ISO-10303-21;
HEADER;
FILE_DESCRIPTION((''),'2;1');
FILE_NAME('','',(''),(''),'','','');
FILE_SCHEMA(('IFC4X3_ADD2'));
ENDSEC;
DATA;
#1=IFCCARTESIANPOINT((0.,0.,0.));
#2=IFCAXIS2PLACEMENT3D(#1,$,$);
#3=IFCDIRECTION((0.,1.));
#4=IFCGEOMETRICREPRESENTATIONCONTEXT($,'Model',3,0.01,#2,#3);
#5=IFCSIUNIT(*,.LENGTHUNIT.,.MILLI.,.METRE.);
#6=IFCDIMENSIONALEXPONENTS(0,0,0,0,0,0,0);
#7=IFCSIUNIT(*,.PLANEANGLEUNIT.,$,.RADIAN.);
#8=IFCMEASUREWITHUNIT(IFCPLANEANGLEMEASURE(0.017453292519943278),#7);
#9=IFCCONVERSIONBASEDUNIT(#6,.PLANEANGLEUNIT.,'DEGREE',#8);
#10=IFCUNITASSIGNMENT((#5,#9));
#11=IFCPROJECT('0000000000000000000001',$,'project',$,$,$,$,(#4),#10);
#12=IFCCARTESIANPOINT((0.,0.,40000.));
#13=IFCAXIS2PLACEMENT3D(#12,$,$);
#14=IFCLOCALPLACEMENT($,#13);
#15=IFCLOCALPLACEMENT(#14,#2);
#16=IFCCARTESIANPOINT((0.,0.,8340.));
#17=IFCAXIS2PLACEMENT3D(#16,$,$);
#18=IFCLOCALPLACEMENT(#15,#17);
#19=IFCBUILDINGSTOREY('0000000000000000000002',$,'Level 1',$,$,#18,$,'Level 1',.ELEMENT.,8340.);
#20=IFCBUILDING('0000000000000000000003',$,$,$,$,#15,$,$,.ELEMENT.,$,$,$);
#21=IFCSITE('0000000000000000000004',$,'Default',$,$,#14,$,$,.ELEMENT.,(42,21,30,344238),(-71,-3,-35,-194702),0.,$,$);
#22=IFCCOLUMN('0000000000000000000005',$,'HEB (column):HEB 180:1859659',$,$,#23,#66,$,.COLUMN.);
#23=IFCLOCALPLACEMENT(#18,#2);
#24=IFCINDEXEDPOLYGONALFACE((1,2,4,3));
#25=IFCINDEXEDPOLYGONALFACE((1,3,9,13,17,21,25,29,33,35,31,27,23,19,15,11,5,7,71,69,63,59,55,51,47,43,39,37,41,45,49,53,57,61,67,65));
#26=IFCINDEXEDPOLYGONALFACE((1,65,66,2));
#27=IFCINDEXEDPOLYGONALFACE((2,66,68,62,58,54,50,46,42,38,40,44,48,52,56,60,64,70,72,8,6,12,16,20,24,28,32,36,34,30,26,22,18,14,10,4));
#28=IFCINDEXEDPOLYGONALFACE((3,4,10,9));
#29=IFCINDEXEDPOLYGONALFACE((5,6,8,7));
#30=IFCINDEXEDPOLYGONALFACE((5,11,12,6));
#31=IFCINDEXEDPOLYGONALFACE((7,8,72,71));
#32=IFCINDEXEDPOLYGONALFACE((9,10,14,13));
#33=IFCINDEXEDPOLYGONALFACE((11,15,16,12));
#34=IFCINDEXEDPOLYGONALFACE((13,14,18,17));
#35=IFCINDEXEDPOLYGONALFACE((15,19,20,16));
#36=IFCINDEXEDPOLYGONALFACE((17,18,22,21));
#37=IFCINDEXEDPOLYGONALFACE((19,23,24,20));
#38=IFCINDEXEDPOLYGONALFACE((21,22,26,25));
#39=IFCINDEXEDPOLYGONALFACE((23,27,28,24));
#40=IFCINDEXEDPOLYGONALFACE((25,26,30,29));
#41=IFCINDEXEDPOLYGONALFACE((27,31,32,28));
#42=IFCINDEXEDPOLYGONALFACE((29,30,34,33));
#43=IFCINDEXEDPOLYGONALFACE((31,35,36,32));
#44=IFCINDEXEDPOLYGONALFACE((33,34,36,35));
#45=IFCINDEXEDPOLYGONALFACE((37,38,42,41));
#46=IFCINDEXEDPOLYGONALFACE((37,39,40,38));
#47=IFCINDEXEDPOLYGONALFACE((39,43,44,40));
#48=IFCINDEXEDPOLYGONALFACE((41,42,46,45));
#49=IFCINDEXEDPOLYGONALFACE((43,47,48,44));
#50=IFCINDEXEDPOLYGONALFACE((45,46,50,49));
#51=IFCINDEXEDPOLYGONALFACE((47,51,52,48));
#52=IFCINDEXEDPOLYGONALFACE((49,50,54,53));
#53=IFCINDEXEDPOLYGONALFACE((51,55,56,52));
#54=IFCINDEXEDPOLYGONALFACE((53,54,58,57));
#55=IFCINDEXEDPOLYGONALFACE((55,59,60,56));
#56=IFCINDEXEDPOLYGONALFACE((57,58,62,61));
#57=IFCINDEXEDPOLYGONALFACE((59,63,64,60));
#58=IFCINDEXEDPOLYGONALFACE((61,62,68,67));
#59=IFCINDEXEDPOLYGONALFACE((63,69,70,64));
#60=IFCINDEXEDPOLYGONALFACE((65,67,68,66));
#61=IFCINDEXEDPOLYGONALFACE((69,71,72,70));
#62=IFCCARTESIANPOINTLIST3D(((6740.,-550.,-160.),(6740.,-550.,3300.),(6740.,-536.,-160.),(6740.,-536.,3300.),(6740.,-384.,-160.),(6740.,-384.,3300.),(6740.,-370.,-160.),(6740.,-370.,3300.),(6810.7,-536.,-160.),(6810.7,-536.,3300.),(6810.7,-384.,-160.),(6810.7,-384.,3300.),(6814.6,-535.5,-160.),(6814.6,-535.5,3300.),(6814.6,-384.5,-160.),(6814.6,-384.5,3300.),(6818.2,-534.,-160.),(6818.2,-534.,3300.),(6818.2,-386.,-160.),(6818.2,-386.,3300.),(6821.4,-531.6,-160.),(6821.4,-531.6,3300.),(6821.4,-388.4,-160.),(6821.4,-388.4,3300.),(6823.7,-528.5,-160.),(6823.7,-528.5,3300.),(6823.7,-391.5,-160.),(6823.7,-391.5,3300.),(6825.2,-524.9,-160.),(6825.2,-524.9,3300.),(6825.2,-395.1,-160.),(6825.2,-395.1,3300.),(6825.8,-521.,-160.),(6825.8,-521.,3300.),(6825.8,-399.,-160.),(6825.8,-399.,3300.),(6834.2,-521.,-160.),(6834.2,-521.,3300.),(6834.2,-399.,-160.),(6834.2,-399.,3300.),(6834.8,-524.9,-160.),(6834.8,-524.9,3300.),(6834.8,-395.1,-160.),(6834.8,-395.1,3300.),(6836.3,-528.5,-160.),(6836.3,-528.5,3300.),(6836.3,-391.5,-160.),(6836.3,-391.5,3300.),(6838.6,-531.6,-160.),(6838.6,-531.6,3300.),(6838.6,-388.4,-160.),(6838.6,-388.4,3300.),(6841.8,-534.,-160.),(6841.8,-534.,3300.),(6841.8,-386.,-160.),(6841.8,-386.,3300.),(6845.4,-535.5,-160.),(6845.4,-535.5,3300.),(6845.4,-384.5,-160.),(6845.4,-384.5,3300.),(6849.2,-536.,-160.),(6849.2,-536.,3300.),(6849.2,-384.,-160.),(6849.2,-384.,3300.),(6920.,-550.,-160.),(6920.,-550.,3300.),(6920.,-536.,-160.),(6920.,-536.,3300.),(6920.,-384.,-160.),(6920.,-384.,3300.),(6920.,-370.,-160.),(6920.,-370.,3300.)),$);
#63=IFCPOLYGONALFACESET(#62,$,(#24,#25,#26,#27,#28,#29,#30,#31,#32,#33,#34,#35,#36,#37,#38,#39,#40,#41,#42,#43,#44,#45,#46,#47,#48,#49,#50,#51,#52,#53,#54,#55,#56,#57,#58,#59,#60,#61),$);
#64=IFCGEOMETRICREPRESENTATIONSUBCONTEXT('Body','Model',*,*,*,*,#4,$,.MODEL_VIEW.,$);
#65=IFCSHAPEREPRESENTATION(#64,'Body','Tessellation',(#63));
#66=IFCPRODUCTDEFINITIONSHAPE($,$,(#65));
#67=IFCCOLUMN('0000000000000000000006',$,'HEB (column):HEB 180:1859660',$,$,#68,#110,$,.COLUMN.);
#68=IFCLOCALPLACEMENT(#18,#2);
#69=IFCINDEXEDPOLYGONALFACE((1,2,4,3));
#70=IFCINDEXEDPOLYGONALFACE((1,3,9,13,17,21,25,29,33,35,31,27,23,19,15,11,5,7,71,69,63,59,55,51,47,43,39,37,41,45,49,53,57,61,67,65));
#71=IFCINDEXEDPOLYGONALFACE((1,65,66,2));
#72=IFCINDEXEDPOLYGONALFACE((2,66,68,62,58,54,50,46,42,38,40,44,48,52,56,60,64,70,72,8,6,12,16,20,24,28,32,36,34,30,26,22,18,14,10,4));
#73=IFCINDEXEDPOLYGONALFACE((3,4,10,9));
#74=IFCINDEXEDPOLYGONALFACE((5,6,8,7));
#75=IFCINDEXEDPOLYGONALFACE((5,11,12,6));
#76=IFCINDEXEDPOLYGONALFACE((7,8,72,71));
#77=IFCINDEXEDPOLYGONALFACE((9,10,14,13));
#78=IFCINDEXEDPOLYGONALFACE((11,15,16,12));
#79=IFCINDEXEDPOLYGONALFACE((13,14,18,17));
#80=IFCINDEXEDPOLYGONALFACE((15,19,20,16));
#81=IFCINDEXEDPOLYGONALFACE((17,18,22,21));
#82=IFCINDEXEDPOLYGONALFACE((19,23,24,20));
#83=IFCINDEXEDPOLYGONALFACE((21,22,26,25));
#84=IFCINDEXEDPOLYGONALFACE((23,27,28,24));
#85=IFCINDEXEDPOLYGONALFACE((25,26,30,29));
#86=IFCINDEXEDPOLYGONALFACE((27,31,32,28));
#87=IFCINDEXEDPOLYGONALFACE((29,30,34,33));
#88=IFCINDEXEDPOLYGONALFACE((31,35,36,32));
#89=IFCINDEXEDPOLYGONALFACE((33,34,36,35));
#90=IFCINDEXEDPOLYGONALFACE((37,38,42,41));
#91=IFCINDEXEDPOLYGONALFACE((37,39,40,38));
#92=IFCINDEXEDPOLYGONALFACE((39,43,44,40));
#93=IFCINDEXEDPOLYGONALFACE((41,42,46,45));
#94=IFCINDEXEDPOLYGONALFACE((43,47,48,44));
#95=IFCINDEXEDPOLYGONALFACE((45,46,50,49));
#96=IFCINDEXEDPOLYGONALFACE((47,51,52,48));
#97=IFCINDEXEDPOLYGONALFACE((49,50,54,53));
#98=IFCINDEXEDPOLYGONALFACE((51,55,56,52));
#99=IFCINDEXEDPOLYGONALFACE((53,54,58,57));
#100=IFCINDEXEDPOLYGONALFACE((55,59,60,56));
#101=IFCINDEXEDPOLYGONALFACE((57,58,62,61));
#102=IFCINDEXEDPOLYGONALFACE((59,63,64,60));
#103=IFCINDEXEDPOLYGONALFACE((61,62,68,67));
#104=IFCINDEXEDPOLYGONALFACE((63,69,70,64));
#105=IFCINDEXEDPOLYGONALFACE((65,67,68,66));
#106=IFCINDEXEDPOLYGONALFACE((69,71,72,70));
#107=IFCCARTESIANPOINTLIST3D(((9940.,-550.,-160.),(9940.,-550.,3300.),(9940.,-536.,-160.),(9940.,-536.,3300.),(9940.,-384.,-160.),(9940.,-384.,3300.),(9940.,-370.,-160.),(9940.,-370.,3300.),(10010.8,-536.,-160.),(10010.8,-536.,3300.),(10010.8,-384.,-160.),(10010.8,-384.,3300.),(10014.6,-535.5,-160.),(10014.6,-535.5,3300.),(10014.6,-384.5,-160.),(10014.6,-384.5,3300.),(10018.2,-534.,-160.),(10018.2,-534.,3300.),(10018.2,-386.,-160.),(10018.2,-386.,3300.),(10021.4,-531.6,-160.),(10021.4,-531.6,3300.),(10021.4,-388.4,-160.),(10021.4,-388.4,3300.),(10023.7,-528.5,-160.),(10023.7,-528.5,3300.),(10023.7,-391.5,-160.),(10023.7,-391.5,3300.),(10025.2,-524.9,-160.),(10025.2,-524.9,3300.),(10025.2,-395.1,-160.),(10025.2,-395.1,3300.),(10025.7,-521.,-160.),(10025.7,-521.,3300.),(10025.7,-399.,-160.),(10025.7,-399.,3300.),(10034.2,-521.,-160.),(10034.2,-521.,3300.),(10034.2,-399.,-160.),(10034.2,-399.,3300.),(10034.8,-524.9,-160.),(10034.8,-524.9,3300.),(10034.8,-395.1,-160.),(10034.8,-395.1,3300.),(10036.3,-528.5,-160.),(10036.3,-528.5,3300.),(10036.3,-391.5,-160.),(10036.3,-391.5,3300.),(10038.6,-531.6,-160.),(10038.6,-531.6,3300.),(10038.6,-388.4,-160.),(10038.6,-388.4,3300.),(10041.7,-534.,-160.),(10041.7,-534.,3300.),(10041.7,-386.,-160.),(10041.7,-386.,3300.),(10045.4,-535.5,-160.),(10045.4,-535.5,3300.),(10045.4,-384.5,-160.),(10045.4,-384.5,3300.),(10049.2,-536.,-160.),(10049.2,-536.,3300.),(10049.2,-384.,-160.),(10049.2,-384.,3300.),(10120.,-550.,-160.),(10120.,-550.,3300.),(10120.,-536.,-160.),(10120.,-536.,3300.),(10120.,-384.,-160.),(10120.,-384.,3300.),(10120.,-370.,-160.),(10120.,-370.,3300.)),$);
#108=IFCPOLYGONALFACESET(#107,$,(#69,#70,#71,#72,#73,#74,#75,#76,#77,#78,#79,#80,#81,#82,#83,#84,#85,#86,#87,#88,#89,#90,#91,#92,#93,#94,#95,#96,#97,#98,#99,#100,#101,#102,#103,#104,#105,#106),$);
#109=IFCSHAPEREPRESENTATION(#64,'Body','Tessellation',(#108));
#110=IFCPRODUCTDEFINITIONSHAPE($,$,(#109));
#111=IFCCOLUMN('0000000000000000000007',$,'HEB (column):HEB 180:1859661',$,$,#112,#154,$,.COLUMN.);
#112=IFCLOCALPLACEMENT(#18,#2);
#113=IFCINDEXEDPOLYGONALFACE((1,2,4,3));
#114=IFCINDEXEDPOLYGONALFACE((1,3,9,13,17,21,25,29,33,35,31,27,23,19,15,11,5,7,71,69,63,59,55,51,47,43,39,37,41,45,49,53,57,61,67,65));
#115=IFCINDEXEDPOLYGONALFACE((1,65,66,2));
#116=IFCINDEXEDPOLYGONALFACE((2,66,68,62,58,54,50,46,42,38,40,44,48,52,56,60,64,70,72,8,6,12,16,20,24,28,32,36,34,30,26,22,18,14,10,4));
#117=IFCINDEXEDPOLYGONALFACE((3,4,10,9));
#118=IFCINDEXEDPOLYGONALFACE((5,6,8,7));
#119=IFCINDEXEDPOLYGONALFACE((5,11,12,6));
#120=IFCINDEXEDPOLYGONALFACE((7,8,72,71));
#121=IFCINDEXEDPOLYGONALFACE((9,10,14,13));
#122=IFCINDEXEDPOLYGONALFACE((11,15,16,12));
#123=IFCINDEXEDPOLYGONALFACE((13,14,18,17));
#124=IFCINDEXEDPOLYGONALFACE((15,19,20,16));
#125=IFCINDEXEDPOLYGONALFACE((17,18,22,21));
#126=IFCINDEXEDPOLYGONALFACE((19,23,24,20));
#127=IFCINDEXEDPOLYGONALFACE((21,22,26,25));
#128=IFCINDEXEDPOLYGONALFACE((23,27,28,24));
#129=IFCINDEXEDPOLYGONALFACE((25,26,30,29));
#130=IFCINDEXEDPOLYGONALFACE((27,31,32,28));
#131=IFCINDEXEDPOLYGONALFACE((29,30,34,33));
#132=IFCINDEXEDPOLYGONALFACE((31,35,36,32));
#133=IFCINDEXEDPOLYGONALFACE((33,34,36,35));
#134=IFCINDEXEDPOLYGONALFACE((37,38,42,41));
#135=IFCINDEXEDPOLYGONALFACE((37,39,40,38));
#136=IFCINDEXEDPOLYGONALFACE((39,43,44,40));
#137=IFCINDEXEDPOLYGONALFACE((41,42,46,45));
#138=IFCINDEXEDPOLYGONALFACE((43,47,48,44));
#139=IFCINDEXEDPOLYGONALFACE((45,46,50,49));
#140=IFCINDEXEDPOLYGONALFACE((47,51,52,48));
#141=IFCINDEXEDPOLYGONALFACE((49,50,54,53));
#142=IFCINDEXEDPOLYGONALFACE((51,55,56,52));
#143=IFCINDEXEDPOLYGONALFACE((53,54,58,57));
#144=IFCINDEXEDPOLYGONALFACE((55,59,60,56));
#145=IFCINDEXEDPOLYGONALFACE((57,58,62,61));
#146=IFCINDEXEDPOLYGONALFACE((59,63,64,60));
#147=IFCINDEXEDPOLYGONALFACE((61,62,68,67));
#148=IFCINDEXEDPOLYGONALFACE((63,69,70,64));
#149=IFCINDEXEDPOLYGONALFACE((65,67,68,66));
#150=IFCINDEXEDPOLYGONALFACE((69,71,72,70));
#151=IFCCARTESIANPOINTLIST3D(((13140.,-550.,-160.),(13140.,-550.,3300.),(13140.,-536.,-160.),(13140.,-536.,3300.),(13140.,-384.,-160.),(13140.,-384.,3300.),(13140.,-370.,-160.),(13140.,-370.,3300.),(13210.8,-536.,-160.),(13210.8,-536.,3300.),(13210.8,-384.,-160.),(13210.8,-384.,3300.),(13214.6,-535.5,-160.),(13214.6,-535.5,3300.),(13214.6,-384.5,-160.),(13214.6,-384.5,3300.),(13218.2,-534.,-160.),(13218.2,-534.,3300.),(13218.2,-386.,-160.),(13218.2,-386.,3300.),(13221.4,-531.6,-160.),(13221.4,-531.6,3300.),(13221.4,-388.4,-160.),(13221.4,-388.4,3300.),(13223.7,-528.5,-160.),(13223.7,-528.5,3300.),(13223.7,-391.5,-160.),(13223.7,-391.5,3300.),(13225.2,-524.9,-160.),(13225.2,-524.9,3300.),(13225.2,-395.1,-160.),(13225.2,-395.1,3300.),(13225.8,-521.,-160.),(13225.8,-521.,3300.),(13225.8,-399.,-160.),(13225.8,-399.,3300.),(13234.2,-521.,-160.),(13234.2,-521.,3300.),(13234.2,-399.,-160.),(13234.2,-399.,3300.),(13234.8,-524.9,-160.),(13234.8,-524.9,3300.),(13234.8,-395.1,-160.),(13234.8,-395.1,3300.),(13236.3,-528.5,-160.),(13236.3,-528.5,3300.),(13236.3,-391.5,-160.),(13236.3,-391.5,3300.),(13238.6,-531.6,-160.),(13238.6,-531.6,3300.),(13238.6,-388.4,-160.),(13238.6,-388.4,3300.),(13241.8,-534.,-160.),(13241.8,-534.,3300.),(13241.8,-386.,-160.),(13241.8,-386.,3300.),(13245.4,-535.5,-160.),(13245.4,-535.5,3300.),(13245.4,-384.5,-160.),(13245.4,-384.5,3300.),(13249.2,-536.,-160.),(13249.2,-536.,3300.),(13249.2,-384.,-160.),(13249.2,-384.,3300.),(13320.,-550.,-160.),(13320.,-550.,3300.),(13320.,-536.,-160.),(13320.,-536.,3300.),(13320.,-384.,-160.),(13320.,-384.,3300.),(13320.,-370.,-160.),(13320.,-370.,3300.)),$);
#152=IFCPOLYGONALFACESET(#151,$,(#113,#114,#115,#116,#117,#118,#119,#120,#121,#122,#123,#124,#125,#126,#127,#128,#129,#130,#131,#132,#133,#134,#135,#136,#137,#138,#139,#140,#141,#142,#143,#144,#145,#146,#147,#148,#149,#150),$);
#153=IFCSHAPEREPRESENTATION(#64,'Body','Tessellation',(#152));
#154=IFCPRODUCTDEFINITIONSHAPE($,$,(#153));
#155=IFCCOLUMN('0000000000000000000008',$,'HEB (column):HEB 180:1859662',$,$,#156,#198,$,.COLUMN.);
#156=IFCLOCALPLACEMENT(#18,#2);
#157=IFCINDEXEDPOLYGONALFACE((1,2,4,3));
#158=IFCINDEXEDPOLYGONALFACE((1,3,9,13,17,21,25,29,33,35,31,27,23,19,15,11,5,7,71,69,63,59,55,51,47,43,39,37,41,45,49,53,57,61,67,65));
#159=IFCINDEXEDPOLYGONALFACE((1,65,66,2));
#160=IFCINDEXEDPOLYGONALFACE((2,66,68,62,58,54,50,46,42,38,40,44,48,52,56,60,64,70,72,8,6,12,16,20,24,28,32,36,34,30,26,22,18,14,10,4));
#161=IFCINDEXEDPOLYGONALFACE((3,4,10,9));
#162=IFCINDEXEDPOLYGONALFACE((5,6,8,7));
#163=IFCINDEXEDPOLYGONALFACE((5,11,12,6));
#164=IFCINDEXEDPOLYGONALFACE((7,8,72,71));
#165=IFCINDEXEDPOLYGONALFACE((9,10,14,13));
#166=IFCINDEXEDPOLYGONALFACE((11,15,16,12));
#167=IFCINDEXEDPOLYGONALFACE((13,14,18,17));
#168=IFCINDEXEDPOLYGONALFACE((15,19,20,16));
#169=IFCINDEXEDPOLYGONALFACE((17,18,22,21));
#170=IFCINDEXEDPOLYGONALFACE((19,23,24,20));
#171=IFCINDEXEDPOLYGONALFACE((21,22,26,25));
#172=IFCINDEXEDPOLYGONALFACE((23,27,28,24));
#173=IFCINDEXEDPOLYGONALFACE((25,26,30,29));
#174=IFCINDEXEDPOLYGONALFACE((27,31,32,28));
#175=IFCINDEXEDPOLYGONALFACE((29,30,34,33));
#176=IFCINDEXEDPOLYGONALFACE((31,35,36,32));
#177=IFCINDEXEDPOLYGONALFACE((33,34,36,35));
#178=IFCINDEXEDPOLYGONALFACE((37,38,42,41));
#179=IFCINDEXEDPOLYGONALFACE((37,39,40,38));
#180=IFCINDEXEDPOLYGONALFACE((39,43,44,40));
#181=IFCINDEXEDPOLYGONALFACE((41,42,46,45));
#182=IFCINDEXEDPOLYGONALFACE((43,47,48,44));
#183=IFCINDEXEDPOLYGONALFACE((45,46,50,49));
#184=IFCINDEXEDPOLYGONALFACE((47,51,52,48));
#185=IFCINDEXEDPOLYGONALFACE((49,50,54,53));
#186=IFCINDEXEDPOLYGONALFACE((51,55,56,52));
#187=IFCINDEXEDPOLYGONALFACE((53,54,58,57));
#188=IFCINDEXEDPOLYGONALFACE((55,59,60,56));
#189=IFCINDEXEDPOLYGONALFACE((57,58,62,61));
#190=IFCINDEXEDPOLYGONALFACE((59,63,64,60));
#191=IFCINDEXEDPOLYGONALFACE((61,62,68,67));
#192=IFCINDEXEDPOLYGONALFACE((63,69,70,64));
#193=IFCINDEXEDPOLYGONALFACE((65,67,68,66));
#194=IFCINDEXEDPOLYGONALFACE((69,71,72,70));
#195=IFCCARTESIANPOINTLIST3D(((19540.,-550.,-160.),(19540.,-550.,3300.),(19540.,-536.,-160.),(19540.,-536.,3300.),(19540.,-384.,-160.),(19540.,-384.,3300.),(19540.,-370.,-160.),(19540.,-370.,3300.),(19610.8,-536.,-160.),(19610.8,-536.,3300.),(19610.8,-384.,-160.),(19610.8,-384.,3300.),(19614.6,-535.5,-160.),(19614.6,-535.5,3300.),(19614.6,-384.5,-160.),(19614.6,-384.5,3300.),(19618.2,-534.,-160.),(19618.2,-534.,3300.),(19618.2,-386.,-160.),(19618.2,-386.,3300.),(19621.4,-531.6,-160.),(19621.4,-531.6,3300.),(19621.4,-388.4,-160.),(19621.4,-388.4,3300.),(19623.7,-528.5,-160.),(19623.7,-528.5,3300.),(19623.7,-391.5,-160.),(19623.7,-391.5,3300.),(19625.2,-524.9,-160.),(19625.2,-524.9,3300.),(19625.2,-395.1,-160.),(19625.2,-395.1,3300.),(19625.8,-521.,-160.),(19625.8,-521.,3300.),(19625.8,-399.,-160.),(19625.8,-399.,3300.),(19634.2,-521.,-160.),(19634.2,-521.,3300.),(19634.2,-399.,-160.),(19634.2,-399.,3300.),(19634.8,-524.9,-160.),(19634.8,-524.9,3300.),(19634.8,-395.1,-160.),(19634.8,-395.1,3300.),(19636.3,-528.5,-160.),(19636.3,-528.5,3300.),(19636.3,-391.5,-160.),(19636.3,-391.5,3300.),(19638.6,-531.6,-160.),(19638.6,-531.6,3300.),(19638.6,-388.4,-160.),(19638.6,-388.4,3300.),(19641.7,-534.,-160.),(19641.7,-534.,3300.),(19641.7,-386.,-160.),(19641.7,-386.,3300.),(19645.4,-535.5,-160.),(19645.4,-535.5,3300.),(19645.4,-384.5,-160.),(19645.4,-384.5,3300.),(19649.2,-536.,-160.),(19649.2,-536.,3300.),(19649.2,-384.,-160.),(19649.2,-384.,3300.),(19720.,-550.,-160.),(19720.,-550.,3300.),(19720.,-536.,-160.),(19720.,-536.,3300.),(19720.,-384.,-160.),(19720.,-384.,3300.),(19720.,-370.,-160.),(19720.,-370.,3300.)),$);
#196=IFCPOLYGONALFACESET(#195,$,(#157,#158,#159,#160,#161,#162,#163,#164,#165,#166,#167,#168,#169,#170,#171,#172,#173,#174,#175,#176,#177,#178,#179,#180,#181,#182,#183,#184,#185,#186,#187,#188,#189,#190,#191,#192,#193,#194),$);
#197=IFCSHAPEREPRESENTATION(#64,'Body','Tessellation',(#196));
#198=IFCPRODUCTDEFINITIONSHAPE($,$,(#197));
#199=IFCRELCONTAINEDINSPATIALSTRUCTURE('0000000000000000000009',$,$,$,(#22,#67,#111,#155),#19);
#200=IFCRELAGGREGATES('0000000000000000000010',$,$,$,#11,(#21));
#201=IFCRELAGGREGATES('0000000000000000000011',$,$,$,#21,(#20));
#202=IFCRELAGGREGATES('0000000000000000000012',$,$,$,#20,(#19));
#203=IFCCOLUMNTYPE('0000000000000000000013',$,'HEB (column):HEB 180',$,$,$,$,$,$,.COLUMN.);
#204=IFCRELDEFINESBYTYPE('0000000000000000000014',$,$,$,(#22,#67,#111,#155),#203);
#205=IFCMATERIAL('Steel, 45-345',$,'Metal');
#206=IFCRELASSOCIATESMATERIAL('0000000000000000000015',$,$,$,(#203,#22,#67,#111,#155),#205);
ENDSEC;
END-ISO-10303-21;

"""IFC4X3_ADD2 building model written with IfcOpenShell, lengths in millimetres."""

from ifc_helpers import new_model, entity, si_unit, converted_unit, direction, frame, origin, origin_2d_with_axis, place, context, subcontext, project, spatial, i_section, extrude, source, transform, mapped, material, material_profile, profile_set, profile_usage, type_object, type_shapes, element, save


model = new_model("IFC4X3_ADD2")

# Units and contexts
model_context = context("Model", 3, precision=0.01, world=origin(), true_north=direction((0.0, 1.0)))
body_context = subcontext(model_context, "Body", "Model", "MODEL_VIEW")
ifc_project = project(units=[si_unit("LENGTHUNIT", "METRE", prefix="MILLI"), converted_unit("PLANEANGLEUNIT", "DEGREE", entity("IfcPlaneAngleMeasure", 0.017453292519943278), si_unit("PLANEANGLEUNIT", "RADIAN"), dimensions=[0, 0, 0, 0, 0, 0, 0])], contexts=[model_context])

# Site, building, storey
site_placement = place(None, frame((0.0, 0.0, 40000.0)))
site = spatial("IfcSite", under=ifc_project, at=site_placement, Name="Default", CompositionType="ELEMENT", RefLatitude=(42, 21, 30, 344238), RefLongitude=(-71, -3, -35, -194702), RefElevation=0.0)
building_placement = place(site_placement, origin())
building = spatial("IfcBuilding", under=site, at=building_placement, CompositionType="ELEMENT")
storey_placement = place(building_placement, frame((0.0, 0.0, 8340.0)))
storey = spatial("IfcBuildingStorey", under=building, at=storey_placement, Name="Level 1", LongName="Level 1", CompositionType="ELEMENT", Elevation=8340.0)

# Columns
ifc_material_1 = material(Name="Steel, 45-345", Category="Metal")
ifc_material_profile_1 = material_profile(ifc_material_1, i_section(OverallWidth=180.0, OverallDepth=180.0, WebThickness=8.5, FlangeThickness=14.0, FilletRadius=15.0, at=origin_2d_with_axis()), Name="HEB 180")
ifc_profile_set_1 = profile_set([ifc_material_profile_1], Name="HEB 180")
ifc_profile_usage_1 = profile_usage(ifc_profile_set_1)
column_type = type_object("IfcColumnType", Name="HEB (column):HEB 180", PredefinedType="COLUMN", material=ifc_profile_set_1)
shared_shape_1 = source(origin(), body_context, "Body", "SweptSolid", [
    extrude(i_section(OverallWidth=180.0, OverallDepth=180.0, WebThickness=8.5, FlangeThickness=14.0, FilletRadius=15.0, at=origin_2d_with_axis()), frame((0.0, 0.0, 8180.0), z_axis=(0.0, 0.0, 1.0), x_axis=(-1.0, 0.0, 0.0)), (0.0, 0.0, 1.0), 3460.0),
])
type_shapes(column_type, [shared_shape_1])
for number, where, name in (
    (1, (6830.0, -460.0, -8340.0), "HEB (column):HEB 180:1859659"),
    (2, (10030.0, -460.0, -8340.0), "HEB (column):HEB 180:1859660"),
    (3, (13230.0, -460.0, -8340.0), "HEB (column):HEB 180:1859661"),
    (4, (19630.0, -460.0, -8340.0), "HEB (column):HEB 180:1859662"),
):
    element("IfcColumn", number, at=place(storey_placement, frame(where)), inside=storey, type_object=column_type, material=ifc_profile_usage_1, Name=name, PredefinedType="COLUMN", context=body_context, shape_type="MappedRepresentation", body=[
        mapped(shared_shape_1, transform((0.0, 0.0, 0.0), scale=1.0)),
    ])

save(model, "model.ifc")
